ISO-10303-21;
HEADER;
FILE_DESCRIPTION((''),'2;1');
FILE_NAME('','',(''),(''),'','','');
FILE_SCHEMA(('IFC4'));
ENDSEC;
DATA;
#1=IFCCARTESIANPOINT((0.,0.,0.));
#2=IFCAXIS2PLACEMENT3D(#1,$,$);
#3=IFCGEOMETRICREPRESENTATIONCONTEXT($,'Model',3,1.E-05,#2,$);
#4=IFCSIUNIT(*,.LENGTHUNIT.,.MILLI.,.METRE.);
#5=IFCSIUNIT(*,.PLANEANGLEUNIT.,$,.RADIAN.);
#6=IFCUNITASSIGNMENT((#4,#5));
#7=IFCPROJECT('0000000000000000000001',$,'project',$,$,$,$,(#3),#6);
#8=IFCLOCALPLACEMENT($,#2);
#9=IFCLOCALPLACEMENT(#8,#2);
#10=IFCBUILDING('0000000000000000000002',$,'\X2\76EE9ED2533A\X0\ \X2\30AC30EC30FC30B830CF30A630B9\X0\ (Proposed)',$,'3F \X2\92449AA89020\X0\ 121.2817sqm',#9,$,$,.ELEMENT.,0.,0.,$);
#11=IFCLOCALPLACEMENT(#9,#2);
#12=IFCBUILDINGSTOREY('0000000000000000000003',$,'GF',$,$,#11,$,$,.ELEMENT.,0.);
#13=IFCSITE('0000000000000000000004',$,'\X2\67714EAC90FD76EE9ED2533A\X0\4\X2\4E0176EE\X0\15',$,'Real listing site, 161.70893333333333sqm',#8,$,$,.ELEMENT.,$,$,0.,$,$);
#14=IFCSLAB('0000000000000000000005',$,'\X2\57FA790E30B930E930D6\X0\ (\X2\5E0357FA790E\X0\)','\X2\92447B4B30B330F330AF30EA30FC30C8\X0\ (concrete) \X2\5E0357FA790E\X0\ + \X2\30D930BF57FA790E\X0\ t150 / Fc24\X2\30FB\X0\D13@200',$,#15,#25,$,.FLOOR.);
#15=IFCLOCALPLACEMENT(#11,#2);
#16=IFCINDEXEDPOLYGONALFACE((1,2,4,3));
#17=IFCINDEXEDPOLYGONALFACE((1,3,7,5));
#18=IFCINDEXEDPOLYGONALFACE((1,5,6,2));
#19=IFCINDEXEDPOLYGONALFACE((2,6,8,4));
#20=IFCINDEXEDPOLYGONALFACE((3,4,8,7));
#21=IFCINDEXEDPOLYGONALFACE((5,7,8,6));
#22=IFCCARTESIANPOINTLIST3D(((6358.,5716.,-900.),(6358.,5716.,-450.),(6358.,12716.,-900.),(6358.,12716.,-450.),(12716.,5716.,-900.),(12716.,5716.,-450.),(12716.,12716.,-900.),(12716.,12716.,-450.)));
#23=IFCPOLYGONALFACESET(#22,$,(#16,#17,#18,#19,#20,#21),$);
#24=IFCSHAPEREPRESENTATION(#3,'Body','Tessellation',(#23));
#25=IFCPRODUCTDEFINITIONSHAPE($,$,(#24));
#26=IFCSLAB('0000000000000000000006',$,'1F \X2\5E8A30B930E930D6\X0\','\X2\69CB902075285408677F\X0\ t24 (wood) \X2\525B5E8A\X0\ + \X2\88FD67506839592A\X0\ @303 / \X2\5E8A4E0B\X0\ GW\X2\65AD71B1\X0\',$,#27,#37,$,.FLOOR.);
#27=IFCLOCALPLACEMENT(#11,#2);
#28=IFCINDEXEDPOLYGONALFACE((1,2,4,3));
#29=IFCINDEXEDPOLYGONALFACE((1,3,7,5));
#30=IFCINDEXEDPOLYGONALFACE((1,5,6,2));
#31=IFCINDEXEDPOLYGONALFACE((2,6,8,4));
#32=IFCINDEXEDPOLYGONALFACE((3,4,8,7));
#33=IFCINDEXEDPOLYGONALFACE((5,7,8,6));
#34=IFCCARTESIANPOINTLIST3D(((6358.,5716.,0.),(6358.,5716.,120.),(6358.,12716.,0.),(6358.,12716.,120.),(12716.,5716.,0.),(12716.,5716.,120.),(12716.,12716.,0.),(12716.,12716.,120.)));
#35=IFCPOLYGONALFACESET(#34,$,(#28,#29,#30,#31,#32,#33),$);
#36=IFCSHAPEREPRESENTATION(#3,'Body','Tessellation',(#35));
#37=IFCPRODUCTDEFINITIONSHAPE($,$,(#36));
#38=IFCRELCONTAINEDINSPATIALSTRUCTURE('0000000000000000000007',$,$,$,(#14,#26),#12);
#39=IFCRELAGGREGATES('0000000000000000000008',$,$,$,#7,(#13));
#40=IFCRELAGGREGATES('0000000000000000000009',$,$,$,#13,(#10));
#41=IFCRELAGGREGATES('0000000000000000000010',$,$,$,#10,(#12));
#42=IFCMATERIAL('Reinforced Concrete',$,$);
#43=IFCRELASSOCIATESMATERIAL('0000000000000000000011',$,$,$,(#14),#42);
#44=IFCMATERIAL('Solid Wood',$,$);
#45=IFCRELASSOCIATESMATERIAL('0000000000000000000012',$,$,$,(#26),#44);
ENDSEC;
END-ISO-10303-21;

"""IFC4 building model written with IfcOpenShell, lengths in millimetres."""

from ifc_helpers import new_model, si_unit, frame, frame_2d, origin, place, context, project, spatial, rectangle, extrude, material, element, save


model = new_model("IFC4")

# Units and contexts
model_context = context("Model", 3, precision=1e-05, world=origin())
ifc_project = project(units=[si_unit("LENGTHUNIT", "METRE", prefix="MILLI"), si_unit("PLANEANGLEUNIT", "RADIAN")], contexts=[model_context])

# Site, building, storey
site_placement = place(None, origin())
site = spatial("IfcSite", under=ifc_project, at=site_placement, Name="東京都目黒区4丁目15", ObjectType="Real listing site, 161.70893333333333sqm", CompositionType="ELEMENT", RefElevation=0.0)
building_placement = place(site_placement, origin())
building = spatial("IfcBuilding", under=site, at=building_placement, Name="目黒区 ガレージハウス (Proposed)", ObjectType="3F 鉄骨造 121.2817sqm", CompositionType="ELEMENT", ElevationOfRefHeight=0.0, ElevationOfTerrain=0.0)
storey_placement = place(building_placement, origin())
storey = spatial("IfcBuildingStorey", under=building, at=storey_placement, Name="GF", CompositionType="ELEMENT", Elevation=0.0)

# Slabs
ifc_material_1 = material(Name="Reinforced Concrete")
slab_1_placement = place(storey_placement, frame((3179.0, 2858.0, -450.0)))
element("IfcSlab", 1, at=slab_1_placement, inside=storey, material=ifc_material_1, Name="基礎スラブ (布基礎)", Description="鉄筋コンクリート (concrete) 布基礎 + ベタ基礎 t150 / Fc24・D13@200", PredefinedType="FLOOR", context=model_context, shape_type="SweptSolid", body=[
    extrude(rectangle(XDim=6358.0, YDim=7000.0, at=frame_2d((3179.0, 3500.0))), frame((3179.0, 2858.0, -450.0)), (0.0, 0.0, 1.0), 450.0),
])
ifc_material_2 = material(Name="Solid Wood")
slab_2_placement = place(storey_placement, frame((3179.0, 2858.0, 0.0)))
element("IfcSlab", 2, at=slab_2_placement, inside=storey, material=ifc_material_2, Name="1F 床スラブ", Description="構造用合板 t24 (wood) 剛床 + 製材根太 @303 / 床下 GW断熱", PredefinedType="FLOOR", context=model_context, shape_type="SweptSolid", body=[
    extrude(rectangle(XDim=6358.0, YDim=7000.0, at=frame_2d((3179.0, 3500.0))), frame((3179.0, 2858.0, 0.0)), (0.0, 0.0, 1.0), 120.0),
])

save(model, "model.ifc")
